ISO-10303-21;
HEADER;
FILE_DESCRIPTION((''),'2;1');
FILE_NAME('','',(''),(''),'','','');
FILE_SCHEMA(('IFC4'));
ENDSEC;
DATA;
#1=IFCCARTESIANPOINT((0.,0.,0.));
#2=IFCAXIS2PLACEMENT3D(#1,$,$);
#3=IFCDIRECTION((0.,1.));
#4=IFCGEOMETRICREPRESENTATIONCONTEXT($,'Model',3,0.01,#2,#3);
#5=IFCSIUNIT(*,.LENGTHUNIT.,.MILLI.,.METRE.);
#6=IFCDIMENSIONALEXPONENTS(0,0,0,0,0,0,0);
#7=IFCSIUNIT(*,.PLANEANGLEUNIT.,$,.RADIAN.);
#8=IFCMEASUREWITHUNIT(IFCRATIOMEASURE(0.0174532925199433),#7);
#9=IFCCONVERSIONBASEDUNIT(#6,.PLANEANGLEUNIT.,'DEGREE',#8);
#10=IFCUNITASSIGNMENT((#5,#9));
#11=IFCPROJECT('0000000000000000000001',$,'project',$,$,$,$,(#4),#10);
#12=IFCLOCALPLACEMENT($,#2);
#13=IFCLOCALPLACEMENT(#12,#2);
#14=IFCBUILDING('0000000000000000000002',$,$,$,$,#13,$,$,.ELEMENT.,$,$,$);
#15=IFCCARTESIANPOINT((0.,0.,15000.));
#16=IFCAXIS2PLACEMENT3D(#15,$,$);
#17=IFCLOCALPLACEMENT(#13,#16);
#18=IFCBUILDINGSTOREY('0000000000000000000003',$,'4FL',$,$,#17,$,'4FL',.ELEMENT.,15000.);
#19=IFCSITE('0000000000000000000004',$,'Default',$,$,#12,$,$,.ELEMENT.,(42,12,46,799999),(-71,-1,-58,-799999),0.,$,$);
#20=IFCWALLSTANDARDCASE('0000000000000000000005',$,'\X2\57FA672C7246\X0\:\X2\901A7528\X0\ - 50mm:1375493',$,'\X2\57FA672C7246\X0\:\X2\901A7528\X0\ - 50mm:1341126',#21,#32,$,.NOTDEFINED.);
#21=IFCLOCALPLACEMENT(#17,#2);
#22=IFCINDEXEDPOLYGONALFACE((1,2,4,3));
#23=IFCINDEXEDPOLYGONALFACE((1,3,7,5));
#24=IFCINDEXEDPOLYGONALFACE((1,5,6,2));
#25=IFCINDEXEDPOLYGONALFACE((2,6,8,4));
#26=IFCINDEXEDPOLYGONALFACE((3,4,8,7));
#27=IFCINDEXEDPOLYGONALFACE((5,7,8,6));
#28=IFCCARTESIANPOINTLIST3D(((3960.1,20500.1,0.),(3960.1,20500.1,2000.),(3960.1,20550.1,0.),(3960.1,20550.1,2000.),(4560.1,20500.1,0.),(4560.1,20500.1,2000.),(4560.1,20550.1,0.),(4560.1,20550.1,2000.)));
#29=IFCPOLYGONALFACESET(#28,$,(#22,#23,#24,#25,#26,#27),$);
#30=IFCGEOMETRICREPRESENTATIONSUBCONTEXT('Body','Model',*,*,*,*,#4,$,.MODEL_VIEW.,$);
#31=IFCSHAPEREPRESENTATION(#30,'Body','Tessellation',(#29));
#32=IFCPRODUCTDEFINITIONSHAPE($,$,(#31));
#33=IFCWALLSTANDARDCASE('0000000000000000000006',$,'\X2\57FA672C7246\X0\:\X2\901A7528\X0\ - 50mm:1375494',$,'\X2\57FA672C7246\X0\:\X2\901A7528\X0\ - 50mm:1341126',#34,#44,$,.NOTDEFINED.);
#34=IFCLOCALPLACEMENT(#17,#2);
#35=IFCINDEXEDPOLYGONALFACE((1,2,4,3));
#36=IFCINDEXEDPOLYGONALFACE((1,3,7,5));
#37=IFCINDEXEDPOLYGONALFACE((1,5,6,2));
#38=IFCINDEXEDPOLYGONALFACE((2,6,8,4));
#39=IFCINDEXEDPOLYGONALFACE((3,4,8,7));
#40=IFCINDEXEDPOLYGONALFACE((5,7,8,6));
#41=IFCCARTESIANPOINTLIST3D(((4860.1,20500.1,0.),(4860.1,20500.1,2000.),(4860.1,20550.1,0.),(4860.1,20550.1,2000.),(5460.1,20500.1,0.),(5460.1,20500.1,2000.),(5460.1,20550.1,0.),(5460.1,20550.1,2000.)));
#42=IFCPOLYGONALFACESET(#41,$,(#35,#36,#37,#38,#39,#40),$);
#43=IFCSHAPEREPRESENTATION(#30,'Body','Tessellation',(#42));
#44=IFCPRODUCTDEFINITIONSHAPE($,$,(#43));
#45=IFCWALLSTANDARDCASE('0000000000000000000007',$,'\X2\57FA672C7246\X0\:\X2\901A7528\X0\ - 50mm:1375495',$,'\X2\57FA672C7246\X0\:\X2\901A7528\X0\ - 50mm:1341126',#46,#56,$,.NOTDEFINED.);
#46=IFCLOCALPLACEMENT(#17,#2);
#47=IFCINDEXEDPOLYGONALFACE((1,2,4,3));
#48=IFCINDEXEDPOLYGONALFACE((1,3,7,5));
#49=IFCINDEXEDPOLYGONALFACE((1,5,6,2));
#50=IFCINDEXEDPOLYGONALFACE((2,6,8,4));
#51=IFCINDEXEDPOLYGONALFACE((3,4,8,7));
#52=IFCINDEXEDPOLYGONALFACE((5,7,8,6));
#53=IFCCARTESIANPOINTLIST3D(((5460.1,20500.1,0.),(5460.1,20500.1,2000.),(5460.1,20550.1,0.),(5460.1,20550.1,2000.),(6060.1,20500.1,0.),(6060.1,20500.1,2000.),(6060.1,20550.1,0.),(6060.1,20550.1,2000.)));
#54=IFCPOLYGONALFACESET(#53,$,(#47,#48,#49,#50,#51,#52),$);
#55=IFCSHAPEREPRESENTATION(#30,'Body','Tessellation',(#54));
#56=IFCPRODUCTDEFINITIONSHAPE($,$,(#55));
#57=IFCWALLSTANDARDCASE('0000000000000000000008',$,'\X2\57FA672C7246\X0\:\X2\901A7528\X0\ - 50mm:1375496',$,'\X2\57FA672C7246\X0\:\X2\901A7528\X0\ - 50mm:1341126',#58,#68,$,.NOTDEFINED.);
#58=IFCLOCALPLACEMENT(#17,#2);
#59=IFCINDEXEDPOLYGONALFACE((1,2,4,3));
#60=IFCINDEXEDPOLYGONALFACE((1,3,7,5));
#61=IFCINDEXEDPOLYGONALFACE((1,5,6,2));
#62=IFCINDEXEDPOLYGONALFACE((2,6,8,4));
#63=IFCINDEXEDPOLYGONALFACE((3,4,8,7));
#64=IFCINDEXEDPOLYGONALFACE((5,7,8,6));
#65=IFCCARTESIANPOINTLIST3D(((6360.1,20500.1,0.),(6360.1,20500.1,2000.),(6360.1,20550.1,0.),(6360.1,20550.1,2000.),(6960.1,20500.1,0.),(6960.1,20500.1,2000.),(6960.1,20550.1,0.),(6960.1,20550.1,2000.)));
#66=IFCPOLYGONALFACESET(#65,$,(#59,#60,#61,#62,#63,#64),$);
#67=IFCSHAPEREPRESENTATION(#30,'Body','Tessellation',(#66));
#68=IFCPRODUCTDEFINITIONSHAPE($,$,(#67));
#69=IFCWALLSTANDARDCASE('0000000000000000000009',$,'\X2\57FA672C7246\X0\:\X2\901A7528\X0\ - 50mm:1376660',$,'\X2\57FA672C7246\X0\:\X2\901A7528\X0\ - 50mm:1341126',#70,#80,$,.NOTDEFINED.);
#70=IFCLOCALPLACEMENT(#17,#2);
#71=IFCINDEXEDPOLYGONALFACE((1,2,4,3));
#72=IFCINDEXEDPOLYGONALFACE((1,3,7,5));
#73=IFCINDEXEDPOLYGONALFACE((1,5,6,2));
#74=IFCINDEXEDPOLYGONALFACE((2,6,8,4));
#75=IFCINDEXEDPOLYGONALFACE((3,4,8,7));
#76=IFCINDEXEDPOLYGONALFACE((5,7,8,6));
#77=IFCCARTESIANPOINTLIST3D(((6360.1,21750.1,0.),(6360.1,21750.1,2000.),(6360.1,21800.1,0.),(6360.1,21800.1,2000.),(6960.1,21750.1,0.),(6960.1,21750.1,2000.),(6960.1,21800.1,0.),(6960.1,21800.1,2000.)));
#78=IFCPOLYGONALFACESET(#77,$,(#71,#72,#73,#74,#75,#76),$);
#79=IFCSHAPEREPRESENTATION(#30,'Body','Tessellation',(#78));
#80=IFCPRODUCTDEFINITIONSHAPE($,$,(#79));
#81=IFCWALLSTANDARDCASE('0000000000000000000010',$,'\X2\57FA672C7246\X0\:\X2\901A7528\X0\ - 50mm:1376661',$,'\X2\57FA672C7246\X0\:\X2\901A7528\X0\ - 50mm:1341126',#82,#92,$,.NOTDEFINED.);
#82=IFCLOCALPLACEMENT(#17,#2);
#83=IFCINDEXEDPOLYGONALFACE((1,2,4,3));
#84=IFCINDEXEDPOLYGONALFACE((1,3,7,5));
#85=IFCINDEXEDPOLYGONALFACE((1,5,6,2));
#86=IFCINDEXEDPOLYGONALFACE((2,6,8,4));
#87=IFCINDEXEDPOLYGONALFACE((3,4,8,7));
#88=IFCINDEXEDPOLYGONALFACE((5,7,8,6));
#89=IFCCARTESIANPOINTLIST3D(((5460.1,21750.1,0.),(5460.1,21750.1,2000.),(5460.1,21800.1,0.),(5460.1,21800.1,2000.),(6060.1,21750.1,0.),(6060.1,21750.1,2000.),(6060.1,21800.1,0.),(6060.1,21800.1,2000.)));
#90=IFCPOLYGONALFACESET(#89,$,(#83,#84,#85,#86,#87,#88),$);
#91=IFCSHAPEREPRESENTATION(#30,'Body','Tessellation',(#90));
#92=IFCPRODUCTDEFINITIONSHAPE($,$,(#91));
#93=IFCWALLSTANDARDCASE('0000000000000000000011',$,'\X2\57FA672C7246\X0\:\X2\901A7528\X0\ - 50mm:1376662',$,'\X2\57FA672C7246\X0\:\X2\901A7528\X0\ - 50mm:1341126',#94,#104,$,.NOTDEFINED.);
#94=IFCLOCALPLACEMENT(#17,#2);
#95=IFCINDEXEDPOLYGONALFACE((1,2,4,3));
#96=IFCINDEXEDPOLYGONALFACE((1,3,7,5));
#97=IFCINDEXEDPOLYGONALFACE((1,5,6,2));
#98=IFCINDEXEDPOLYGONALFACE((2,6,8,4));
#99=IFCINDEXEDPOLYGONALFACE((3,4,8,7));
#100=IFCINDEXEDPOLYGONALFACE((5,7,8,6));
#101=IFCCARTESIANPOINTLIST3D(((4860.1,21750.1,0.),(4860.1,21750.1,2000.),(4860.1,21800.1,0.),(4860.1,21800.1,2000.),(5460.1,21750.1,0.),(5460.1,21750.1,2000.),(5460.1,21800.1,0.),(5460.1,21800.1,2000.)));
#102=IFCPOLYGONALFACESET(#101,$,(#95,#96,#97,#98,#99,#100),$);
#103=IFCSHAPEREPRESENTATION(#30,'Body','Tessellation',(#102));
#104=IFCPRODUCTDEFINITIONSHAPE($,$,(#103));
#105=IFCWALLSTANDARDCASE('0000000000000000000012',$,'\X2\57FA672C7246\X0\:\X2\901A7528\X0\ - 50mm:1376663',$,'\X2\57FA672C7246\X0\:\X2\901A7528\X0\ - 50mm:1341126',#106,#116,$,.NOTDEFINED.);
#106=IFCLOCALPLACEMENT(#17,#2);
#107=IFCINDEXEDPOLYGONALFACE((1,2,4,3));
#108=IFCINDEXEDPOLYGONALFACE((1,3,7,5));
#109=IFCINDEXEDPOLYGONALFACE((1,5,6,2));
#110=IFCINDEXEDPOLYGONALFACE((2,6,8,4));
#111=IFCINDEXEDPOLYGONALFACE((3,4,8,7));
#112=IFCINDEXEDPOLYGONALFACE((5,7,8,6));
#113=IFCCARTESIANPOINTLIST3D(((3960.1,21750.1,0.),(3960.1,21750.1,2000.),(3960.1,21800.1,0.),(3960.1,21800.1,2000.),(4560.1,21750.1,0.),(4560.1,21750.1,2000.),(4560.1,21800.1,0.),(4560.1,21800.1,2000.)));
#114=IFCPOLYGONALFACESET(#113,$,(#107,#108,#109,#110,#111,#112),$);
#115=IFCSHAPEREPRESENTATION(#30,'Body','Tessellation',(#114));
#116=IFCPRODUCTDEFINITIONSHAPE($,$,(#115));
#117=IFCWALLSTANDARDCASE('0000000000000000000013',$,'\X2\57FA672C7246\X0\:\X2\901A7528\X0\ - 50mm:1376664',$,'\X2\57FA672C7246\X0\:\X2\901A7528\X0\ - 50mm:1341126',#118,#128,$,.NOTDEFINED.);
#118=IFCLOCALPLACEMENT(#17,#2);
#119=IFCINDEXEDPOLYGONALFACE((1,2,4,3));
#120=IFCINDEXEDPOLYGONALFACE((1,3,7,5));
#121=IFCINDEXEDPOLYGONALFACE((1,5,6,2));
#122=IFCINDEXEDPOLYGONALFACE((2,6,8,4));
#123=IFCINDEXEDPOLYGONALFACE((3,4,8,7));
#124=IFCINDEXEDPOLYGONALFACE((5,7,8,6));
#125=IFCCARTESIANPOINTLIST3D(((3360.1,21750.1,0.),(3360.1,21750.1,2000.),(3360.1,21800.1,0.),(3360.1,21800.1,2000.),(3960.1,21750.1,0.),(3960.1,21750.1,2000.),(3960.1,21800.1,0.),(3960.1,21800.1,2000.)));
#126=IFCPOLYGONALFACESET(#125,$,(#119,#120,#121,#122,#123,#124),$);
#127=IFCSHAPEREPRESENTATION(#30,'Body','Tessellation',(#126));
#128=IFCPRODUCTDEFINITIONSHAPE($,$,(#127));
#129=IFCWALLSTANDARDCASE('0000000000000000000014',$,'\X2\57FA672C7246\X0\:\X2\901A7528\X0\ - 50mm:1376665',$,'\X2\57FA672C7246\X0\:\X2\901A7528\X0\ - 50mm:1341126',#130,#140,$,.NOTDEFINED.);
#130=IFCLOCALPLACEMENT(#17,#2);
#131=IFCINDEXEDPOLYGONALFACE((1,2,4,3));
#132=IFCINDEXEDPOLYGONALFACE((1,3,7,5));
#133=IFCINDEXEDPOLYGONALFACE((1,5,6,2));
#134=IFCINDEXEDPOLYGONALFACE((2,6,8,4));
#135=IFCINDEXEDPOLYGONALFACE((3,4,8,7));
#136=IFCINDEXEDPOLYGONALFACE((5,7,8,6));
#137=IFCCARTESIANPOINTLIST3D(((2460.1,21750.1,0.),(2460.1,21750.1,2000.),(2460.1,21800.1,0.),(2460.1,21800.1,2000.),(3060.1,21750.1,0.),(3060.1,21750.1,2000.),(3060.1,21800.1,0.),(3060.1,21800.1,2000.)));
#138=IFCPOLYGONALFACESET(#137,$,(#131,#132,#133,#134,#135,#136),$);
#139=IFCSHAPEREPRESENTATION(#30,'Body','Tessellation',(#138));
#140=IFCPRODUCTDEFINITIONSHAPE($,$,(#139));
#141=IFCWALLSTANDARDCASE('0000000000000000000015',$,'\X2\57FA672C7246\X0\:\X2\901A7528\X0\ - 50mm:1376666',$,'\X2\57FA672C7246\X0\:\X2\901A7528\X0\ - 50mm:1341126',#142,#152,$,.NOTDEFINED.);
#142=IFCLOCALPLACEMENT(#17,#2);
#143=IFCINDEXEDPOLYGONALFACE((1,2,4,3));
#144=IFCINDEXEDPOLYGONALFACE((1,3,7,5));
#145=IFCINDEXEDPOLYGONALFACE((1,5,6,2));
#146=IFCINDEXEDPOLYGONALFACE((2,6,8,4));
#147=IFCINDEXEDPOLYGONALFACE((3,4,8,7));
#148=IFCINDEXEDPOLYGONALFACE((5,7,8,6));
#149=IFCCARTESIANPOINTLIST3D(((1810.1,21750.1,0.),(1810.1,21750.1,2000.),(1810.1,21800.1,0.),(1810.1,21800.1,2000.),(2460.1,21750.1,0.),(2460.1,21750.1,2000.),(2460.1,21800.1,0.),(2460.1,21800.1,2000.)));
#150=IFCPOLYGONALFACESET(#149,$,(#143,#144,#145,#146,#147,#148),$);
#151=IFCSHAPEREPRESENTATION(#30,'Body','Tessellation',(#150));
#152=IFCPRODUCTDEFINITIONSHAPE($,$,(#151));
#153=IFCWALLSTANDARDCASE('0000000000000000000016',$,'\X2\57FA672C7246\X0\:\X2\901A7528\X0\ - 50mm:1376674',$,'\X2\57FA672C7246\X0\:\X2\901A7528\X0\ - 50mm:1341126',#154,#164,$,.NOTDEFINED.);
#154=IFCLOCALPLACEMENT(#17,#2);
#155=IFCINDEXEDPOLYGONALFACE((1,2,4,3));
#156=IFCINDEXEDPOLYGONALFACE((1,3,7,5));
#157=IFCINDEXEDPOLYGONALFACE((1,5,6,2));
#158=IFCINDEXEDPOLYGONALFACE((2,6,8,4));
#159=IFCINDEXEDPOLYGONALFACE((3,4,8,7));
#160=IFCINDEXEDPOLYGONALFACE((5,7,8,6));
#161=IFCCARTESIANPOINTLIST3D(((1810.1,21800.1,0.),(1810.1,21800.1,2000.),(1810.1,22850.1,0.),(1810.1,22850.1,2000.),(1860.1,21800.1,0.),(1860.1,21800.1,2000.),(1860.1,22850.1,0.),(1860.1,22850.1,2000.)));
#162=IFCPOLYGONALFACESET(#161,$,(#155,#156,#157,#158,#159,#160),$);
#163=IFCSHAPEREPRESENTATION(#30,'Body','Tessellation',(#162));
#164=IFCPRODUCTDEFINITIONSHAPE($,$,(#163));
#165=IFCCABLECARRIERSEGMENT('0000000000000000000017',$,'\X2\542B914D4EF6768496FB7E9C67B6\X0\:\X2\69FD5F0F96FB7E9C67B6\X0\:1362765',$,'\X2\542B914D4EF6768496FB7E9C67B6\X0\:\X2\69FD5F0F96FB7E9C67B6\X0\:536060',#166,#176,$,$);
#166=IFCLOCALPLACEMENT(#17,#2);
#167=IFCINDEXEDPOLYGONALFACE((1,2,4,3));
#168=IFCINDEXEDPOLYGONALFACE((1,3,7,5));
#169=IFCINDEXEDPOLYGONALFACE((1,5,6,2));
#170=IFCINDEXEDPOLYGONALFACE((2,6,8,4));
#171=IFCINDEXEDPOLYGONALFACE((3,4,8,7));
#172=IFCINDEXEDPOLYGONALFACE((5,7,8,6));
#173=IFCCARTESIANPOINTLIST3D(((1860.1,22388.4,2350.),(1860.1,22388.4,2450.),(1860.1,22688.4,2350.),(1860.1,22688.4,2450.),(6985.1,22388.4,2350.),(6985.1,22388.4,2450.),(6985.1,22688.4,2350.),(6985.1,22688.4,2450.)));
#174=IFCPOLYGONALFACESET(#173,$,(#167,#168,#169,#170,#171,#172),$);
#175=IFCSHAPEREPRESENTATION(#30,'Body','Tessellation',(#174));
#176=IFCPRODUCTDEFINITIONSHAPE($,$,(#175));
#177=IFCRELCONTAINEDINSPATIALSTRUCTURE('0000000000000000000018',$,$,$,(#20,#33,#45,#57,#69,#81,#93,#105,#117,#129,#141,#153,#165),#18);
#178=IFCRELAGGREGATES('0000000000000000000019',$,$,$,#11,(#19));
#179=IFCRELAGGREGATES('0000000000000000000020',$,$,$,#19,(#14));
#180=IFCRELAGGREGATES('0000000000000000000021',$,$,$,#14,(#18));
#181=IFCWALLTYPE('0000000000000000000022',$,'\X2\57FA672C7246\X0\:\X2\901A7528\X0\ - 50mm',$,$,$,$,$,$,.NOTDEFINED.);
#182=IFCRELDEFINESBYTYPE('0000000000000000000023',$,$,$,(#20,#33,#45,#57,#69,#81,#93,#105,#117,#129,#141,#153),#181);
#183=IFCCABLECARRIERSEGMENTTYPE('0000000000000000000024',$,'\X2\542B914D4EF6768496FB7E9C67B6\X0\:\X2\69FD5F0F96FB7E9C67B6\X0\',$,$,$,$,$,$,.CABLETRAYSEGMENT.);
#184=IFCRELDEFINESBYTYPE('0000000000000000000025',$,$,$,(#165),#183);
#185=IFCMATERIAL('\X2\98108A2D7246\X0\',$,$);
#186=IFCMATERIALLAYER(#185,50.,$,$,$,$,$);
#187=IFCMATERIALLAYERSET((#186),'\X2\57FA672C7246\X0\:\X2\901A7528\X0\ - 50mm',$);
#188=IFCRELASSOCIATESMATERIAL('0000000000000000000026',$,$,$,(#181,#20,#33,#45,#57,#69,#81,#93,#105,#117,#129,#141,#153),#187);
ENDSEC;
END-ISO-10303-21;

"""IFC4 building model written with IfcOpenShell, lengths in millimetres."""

from ifc_helpers import new_model, entity, si_unit, converted_unit, direction, frame, frame_2d, origin, place, context, subcontext, project, spatial, rectangle, extrude, material, layer, layer_set, layer_usage, type_object, element, save


model = new_model("IFC4")

# Units and contexts
model_context = context("Model", 3, precision=0.01, world=origin(), true_north=direction((0.0, 1.0)))
body_context = subcontext(model_context, "Body", "Model", "MODEL_VIEW")
ifc_project = project(units=[si_unit("LENGTHUNIT", "METRE", prefix="MILLI"), converted_unit("PLANEANGLEUNIT", "DEGREE", entity("IfcRatioMeasure", 0.0174532925199433), si_unit("PLANEANGLEUNIT", "RADIAN"), dimensions=[0, 0, 0, 0, 0, 0, 0])], contexts=[model_context])

# Site, building, storey
site_placement = place(None, origin())
site = spatial("IfcSite", under=ifc_project, at=site_placement, Name="Default", CompositionType="ELEMENT", RefLatitude=(42, 12, 46, 799999), RefLongitude=(-71, -1, -58, -799999), RefElevation=0.0)
building_placement = place(site_placement, origin())
building = spatial("IfcBuilding", under=site, at=building_placement, CompositionType="ELEMENT")
storey_placement = place(building_placement, frame((0.0, 0.0, 15000.0)))
storey = spatial("IfcBuildingStorey", under=building, at=storey_placement, Name="4FL", LongName="4FL", CompositionType="ELEMENT", Elevation=15000.0)

# Shared definitions
ifc_material_1 = material(Name="預設牆")

# Walls
ifc_layer_1 = layer(ifc_material_1, 50.0)
ifc_layer_set_1 = layer_set([ifc_layer_1], Name="基本牆:通用 - 50mm")
ifc_layer_usage_1 = layer_usage(ifc_layer_set_1, "AXIS2", "NEGATIVE", 25.0)
wall_type_1 = type_object("IfcWallType", Name="基本牆:通用 - 50mm", PredefinedType="NOTDEFINED", material=ifc_layer_set_1)
wall_1_placement = place(storey_placement, frame((3960.1, 20525.1, 0.0)))
element("IfcWallStandardCase", 1, at=wall_1_placement, inside=storey, type_object=wall_type_1, material=ifc_layer_usage_1, Name="基本牆:通用 - 50mm:1375493", ObjectType="基本牆:通用 - 50mm:1341126", PredefinedType="NOTDEFINED", context=body_context, shape_type="SweptSolid", body=[
    extrude(rectangle(XDim=600.0, YDim=50.0, at=frame_2d((300.0, 0.0), x_axis=(-1.0, 0.0))), origin(), (0.0, 0.0, 1.0), 2000.0),
])
ifc_layer_usage_2 = layer_usage(ifc_layer_set_1, "AXIS2", "NEGATIVE", 25.0)
wall_2_placement = place(storey_placement, frame((4860.1, 20525.1, 0.0)))
element("IfcWallStandardCase", 2, at=wall_2_placement, inside=storey, type_object=wall_type_1, material=ifc_layer_usage_2, Name="基本牆:通用 - 50mm:1375494", ObjectType="基本牆:通用 - 50mm:1341126", PredefinedType="NOTDEFINED", context=body_context, shape_type="SweptSolid", body=[
    extrude(rectangle(XDim=600.0, YDim=50.0, at=frame_2d((300.0, 0.0), x_axis=(-1.0, 0.0))), origin(), (0.0, 0.0, 1.0), 2000.0),
])
ifc_layer_usage_3 = layer_usage(ifc_layer_set_1, "AXIS2", "NEGATIVE", 25.0)
wall_3_placement = place(storey_placement, frame((5460.1, 20525.1, 0.0)))
element("IfcWallStandardCase", 3, at=wall_3_placement, inside=storey, type_object=wall_type_1, material=ifc_layer_usage_3, Name="基本牆:通用 - 50mm:1375495", ObjectType="基本牆:通用 - 50mm:1341126", PredefinedType="NOTDEFINED", context=body_context, shape_type="SweptSolid", body=[
    extrude(rectangle(XDim=600.0, YDim=50.0, at=frame_2d((300.0, 0.0), x_axis=(-1.0, 0.0))), origin(), (0.0, 0.0, 1.0), 2000.0),
])
ifc_layer_usage_4 = layer_usage(ifc_layer_set_1, "AXIS2", "NEGATIVE", 25.0)
wall_4_placement = place(storey_placement, frame((6360.1, 20525.1, 0.0)))
element("IfcWallStandardCase", 4, at=wall_4_placement, inside=storey, type_object=wall_type_1, material=ifc_layer_usage_4, Name="基本牆:通用 - 50mm:1375496", ObjectType="基本牆:通用 - 50mm:1341126", PredefinedType="NOTDEFINED", context=body_context, shape_type="SweptSolid", body=[
    extrude(rectangle(XDim=600.0, YDim=50.0, at=frame_2d((300.0, 0.0), x_axis=(-1.0, 0.0))), origin(), (0.0, 0.0, 1.0), 2000.0),
])
ifc_layer_usage_5 = layer_usage(ifc_layer_set_1, "AXIS2", "NEGATIVE", 25.0)
wall_5_placement = place(storey_placement, frame((6960.1, 21775.1, 0.0), z_axis=(0.0, 0.0, 1.0), x_axis=(-1.0, 0.0, 0.0)))
element("IfcWallStandardCase", 5, at=wall_5_placement, inside=storey, type_object=wall_type_1, material=ifc_layer_usage_5, Name="基本牆:通用 - 50mm:1376660", ObjectType="基本牆:通用 - 50mm:1341126", PredefinedType="NOTDEFINED", context=body_context, shape_type="SweptSolid", body=[
    extrude(rectangle(XDim=600.0, YDim=50.0, at=frame_2d((300.0, 0.0), x_axis=(-1.0, 0.0))), origin(), (0.0, 0.0, 1.0), 2000.0),
])
ifc_layer_usage_6 = layer_usage(ifc_layer_set_1, "AXIS2", "NEGATIVE", 25.0)
wall_6_placement = place(storey_placement, frame((6060.1, 21775.1, 0.0), z_axis=(0.0, 0.0, 1.0), x_axis=(-1.0, 0.0, 0.0)))
element("IfcWallStandardCase", 6, at=wall_6_placement, inside=storey, type_object=wall_type_1, material=ifc_layer_usage_6, Name="基本牆:通用 - 50mm:1376661", ObjectType="基本牆:通用 - 50mm:1341126", PredefinedType="NOTDEFINED", context=body_context, shape_type="SweptSolid", body=[
    extrude(rectangle(XDim=600.0, YDim=50.0, at=frame_2d((300.0, 0.0), x_axis=(-1.0, 0.0))), origin(), (0.0, 0.0, 1.0), 2000.0),
])
ifc_layer_usage_7 = layer_usage(ifc_layer_set_1, "AXIS2", "NEGATIVE", 25.0)
wall_7_placement = place(storey_placement, frame((5460.1, 21775.1, 0.0), z_axis=(0.0, 0.0, 1.0), x_axis=(-1.0, 0.0, 0.0)))
element("IfcWallStandardCase", 7, at=wall_7_placement, inside=storey, type_object=wall_type_1, material=ifc_layer_usage_7, Name="基本牆:通用 - 50mm:1376662", ObjectType="基本牆:通用 - 50mm:1341126", PredefinedType="NOTDEFINED", context=body_context, shape_type="SweptSolid", body=[
    extrude(rectangle(XDim=600.0, YDim=50.0, at=frame_2d((300.0, 0.0), x_axis=(-1.0, 0.0))), origin(), (0.0, 0.0, 1.0), 2000.0),
])
ifc_layer_usage_8 = layer_usage(ifc_layer_set_1, "AXIS2", "NEGATIVE", 25.0)
wall_8_placement = place(storey_placement, frame((4560.1, 21775.1, 0.0), z_axis=(0.0, 0.0, 1.0), x_axis=(-1.0, 0.0, 0.0)))
element("IfcWallStandardCase", 8, at=wall_8_placement, inside=storey, type_object=wall_type_1, material=ifc_layer_usage_8, Name="基本牆:通用 - 50mm:1376663", ObjectType="基本牆:通用 - 50mm:1341126", PredefinedType="NOTDEFINED", context=body_context, shape_type="SweptSolid", body=[
    extrude(rectangle(XDim=600.0, YDim=50.0, at=frame_2d((300.0, 0.0), x_axis=(-1.0, 0.0))), origin(), (0.0, 0.0, 1.0), 2000.0),
])
ifc_layer_usage_9 = layer_usage(ifc_layer_set_1, "AXIS2", "NEGATIVE", 25.0)
wall_9_placement = place(storey_placement, frame((3960.1, 21775.1, 0.0), z_axis=(0.0, 0.0, 1.0), x_axis=(-1.0, 0.0, 0.0)))
element("IfcWallStandardCase", 9, at=wall_9_placement, inside=storey, type_object=wall_type_1, material=ifc_layer_usage_9, Name="基本牆:通用 - 50mm:1376664", ObjectType="基本牆:通用 - 50mm:1341126", PredefinedType="NOTDEFINED", context=body_context, shape_type="SweptSolid", body=[
    extrude(rectangle(XDim=600.0, YDim=50.0, at=frame_2d((300.0, 0.0), x_axis=(-1.0, 0.0))), origin(), (0.0, 0.0, 1.0), 2000.0),
])
ifc_layer_usage_10 = layer_usage(ifc_layer_set_1, "AXIS2", "NEGATIVE", 25.0)
wall_10_placement = place(storey_placement, frame((3060.1, 21775.1, 0.0), z_axis=(0.0, 0.0, 1.0), x_axis=(-1.0, 0.0, 0.0)))
element("IfcWallStandardCase", 10, at=wall_10_placement, inside=storey, type_object=wall_type_1, material=ifc_layer_usage_10, Name="基本牆:通用 - 50mm:1376665", ObjectType="基本牆:通用 - 50mm:1341126", PredefinedType="NOTDEFINED", context=body_context, shape_type="SweptSolid", body=[
    extrude(rectangle(XDim=600.0, YDim=50.0, at=frame_2d((300.0, 0.0), x_axis=(-1.0, 0.0))), origin(), (0.0, 0.0, 1.0), 2000.0),
])
ifc_layer_usage_11 = layer_usage(ifc_layer_set_1, "AXIS2", "NEGATIVE", 25.0)
wall_11_placement = place(storey_placement, frame((2460.1, 21775.1, 0.0), z_axis=(0.0, 0.0, 1.0), x_axis=(-1.0, 0.0, 0.0)))
element("IfcWallStandardCase", 11, at=wall_11_placement, inside=storey, type_object=wall_type_1, material=ifc_layer_usage_11, Name="基本牆:通用 - 50mm:1376666", ObjectType="基本牆:通用 - 50mm:1341126", PredefinedType="NOTDEFINED", context=body_context, shape_type="SweptSolid", body=[
    extrude(rectangle(XDim=650.0, YDim=50.0, at=frame_2d((325.0, 0.0), x_axis=(-1.0, 0.0))), origin(), (0.0, 0.0, 1.0), 2000.0),
])
ifc_layer_usage_12 = layer_usage(ifc_layer_set_1, "AXIS2", "NEGATIVE", 25.0)
wall_12_placement = place(storey_placement, frame((1835.1, 21800.1, 0.0), z_axis=(0.0, 0.0, 1.0), x_axis=(0.0, 1.0, 0.0)))
element("IfcWallStandardCase", 12, at=wall_12_placement, inside=storey, type_object=wall_type_1, material=ifc_layer_usage_12, Name="基本牆:通用 - 50mm:1376674", ObjectType="基本牆:通用 - 50mm:1341126", PredefinedType="NOTDEFINED", context=body_context, shape_type="SweptSolid", body=[
    extrude(rectangle(XDim=1050.0, YDim=50.0, at=frame_2d((525.0, 0.0), x_axis=(-1.0, 0.0))), origin(), (0.0, 0.0, 1.0), 2000.0),
])

# Cable carrier segment
cable_carrier_segment_type_1 = type_object("IfcCableCarrierSegmentType", Name="含配件的電纜架:槽式電纜架", PredefinedType="CABLETRAYSEGMENT")
cable_carrier_segment_1_placement = place(storey_placement, frame((1860.1, 22388.4, 2350.0)))
element("IfcCableCarrierSegment", 13, at=cable_carrier_segment_1_placement, inside=storey, type_object=cable_carrier_segment_type_1, Name="含配件的電纜架:槽式電纜架:1362765", ObjectType="含配件的電纜架:槽式電纜架:536060", context=body_context, shape_type="SweptSolid", body=[
    extrude(rectangle(XDim=5125.0, YDim=300.0, at=frame_2d((0.0, 0.0), x_axis=(1.0, 0.0))), frame((2562.5, 150.0, 0.0), z_axis=(0.0, 0.0, 1.0), x_axis=(-1.0, 0.0, 0.0)), (0.0, 0.0, 1.0), 100.0),
])

save(model, "model.ifc")
